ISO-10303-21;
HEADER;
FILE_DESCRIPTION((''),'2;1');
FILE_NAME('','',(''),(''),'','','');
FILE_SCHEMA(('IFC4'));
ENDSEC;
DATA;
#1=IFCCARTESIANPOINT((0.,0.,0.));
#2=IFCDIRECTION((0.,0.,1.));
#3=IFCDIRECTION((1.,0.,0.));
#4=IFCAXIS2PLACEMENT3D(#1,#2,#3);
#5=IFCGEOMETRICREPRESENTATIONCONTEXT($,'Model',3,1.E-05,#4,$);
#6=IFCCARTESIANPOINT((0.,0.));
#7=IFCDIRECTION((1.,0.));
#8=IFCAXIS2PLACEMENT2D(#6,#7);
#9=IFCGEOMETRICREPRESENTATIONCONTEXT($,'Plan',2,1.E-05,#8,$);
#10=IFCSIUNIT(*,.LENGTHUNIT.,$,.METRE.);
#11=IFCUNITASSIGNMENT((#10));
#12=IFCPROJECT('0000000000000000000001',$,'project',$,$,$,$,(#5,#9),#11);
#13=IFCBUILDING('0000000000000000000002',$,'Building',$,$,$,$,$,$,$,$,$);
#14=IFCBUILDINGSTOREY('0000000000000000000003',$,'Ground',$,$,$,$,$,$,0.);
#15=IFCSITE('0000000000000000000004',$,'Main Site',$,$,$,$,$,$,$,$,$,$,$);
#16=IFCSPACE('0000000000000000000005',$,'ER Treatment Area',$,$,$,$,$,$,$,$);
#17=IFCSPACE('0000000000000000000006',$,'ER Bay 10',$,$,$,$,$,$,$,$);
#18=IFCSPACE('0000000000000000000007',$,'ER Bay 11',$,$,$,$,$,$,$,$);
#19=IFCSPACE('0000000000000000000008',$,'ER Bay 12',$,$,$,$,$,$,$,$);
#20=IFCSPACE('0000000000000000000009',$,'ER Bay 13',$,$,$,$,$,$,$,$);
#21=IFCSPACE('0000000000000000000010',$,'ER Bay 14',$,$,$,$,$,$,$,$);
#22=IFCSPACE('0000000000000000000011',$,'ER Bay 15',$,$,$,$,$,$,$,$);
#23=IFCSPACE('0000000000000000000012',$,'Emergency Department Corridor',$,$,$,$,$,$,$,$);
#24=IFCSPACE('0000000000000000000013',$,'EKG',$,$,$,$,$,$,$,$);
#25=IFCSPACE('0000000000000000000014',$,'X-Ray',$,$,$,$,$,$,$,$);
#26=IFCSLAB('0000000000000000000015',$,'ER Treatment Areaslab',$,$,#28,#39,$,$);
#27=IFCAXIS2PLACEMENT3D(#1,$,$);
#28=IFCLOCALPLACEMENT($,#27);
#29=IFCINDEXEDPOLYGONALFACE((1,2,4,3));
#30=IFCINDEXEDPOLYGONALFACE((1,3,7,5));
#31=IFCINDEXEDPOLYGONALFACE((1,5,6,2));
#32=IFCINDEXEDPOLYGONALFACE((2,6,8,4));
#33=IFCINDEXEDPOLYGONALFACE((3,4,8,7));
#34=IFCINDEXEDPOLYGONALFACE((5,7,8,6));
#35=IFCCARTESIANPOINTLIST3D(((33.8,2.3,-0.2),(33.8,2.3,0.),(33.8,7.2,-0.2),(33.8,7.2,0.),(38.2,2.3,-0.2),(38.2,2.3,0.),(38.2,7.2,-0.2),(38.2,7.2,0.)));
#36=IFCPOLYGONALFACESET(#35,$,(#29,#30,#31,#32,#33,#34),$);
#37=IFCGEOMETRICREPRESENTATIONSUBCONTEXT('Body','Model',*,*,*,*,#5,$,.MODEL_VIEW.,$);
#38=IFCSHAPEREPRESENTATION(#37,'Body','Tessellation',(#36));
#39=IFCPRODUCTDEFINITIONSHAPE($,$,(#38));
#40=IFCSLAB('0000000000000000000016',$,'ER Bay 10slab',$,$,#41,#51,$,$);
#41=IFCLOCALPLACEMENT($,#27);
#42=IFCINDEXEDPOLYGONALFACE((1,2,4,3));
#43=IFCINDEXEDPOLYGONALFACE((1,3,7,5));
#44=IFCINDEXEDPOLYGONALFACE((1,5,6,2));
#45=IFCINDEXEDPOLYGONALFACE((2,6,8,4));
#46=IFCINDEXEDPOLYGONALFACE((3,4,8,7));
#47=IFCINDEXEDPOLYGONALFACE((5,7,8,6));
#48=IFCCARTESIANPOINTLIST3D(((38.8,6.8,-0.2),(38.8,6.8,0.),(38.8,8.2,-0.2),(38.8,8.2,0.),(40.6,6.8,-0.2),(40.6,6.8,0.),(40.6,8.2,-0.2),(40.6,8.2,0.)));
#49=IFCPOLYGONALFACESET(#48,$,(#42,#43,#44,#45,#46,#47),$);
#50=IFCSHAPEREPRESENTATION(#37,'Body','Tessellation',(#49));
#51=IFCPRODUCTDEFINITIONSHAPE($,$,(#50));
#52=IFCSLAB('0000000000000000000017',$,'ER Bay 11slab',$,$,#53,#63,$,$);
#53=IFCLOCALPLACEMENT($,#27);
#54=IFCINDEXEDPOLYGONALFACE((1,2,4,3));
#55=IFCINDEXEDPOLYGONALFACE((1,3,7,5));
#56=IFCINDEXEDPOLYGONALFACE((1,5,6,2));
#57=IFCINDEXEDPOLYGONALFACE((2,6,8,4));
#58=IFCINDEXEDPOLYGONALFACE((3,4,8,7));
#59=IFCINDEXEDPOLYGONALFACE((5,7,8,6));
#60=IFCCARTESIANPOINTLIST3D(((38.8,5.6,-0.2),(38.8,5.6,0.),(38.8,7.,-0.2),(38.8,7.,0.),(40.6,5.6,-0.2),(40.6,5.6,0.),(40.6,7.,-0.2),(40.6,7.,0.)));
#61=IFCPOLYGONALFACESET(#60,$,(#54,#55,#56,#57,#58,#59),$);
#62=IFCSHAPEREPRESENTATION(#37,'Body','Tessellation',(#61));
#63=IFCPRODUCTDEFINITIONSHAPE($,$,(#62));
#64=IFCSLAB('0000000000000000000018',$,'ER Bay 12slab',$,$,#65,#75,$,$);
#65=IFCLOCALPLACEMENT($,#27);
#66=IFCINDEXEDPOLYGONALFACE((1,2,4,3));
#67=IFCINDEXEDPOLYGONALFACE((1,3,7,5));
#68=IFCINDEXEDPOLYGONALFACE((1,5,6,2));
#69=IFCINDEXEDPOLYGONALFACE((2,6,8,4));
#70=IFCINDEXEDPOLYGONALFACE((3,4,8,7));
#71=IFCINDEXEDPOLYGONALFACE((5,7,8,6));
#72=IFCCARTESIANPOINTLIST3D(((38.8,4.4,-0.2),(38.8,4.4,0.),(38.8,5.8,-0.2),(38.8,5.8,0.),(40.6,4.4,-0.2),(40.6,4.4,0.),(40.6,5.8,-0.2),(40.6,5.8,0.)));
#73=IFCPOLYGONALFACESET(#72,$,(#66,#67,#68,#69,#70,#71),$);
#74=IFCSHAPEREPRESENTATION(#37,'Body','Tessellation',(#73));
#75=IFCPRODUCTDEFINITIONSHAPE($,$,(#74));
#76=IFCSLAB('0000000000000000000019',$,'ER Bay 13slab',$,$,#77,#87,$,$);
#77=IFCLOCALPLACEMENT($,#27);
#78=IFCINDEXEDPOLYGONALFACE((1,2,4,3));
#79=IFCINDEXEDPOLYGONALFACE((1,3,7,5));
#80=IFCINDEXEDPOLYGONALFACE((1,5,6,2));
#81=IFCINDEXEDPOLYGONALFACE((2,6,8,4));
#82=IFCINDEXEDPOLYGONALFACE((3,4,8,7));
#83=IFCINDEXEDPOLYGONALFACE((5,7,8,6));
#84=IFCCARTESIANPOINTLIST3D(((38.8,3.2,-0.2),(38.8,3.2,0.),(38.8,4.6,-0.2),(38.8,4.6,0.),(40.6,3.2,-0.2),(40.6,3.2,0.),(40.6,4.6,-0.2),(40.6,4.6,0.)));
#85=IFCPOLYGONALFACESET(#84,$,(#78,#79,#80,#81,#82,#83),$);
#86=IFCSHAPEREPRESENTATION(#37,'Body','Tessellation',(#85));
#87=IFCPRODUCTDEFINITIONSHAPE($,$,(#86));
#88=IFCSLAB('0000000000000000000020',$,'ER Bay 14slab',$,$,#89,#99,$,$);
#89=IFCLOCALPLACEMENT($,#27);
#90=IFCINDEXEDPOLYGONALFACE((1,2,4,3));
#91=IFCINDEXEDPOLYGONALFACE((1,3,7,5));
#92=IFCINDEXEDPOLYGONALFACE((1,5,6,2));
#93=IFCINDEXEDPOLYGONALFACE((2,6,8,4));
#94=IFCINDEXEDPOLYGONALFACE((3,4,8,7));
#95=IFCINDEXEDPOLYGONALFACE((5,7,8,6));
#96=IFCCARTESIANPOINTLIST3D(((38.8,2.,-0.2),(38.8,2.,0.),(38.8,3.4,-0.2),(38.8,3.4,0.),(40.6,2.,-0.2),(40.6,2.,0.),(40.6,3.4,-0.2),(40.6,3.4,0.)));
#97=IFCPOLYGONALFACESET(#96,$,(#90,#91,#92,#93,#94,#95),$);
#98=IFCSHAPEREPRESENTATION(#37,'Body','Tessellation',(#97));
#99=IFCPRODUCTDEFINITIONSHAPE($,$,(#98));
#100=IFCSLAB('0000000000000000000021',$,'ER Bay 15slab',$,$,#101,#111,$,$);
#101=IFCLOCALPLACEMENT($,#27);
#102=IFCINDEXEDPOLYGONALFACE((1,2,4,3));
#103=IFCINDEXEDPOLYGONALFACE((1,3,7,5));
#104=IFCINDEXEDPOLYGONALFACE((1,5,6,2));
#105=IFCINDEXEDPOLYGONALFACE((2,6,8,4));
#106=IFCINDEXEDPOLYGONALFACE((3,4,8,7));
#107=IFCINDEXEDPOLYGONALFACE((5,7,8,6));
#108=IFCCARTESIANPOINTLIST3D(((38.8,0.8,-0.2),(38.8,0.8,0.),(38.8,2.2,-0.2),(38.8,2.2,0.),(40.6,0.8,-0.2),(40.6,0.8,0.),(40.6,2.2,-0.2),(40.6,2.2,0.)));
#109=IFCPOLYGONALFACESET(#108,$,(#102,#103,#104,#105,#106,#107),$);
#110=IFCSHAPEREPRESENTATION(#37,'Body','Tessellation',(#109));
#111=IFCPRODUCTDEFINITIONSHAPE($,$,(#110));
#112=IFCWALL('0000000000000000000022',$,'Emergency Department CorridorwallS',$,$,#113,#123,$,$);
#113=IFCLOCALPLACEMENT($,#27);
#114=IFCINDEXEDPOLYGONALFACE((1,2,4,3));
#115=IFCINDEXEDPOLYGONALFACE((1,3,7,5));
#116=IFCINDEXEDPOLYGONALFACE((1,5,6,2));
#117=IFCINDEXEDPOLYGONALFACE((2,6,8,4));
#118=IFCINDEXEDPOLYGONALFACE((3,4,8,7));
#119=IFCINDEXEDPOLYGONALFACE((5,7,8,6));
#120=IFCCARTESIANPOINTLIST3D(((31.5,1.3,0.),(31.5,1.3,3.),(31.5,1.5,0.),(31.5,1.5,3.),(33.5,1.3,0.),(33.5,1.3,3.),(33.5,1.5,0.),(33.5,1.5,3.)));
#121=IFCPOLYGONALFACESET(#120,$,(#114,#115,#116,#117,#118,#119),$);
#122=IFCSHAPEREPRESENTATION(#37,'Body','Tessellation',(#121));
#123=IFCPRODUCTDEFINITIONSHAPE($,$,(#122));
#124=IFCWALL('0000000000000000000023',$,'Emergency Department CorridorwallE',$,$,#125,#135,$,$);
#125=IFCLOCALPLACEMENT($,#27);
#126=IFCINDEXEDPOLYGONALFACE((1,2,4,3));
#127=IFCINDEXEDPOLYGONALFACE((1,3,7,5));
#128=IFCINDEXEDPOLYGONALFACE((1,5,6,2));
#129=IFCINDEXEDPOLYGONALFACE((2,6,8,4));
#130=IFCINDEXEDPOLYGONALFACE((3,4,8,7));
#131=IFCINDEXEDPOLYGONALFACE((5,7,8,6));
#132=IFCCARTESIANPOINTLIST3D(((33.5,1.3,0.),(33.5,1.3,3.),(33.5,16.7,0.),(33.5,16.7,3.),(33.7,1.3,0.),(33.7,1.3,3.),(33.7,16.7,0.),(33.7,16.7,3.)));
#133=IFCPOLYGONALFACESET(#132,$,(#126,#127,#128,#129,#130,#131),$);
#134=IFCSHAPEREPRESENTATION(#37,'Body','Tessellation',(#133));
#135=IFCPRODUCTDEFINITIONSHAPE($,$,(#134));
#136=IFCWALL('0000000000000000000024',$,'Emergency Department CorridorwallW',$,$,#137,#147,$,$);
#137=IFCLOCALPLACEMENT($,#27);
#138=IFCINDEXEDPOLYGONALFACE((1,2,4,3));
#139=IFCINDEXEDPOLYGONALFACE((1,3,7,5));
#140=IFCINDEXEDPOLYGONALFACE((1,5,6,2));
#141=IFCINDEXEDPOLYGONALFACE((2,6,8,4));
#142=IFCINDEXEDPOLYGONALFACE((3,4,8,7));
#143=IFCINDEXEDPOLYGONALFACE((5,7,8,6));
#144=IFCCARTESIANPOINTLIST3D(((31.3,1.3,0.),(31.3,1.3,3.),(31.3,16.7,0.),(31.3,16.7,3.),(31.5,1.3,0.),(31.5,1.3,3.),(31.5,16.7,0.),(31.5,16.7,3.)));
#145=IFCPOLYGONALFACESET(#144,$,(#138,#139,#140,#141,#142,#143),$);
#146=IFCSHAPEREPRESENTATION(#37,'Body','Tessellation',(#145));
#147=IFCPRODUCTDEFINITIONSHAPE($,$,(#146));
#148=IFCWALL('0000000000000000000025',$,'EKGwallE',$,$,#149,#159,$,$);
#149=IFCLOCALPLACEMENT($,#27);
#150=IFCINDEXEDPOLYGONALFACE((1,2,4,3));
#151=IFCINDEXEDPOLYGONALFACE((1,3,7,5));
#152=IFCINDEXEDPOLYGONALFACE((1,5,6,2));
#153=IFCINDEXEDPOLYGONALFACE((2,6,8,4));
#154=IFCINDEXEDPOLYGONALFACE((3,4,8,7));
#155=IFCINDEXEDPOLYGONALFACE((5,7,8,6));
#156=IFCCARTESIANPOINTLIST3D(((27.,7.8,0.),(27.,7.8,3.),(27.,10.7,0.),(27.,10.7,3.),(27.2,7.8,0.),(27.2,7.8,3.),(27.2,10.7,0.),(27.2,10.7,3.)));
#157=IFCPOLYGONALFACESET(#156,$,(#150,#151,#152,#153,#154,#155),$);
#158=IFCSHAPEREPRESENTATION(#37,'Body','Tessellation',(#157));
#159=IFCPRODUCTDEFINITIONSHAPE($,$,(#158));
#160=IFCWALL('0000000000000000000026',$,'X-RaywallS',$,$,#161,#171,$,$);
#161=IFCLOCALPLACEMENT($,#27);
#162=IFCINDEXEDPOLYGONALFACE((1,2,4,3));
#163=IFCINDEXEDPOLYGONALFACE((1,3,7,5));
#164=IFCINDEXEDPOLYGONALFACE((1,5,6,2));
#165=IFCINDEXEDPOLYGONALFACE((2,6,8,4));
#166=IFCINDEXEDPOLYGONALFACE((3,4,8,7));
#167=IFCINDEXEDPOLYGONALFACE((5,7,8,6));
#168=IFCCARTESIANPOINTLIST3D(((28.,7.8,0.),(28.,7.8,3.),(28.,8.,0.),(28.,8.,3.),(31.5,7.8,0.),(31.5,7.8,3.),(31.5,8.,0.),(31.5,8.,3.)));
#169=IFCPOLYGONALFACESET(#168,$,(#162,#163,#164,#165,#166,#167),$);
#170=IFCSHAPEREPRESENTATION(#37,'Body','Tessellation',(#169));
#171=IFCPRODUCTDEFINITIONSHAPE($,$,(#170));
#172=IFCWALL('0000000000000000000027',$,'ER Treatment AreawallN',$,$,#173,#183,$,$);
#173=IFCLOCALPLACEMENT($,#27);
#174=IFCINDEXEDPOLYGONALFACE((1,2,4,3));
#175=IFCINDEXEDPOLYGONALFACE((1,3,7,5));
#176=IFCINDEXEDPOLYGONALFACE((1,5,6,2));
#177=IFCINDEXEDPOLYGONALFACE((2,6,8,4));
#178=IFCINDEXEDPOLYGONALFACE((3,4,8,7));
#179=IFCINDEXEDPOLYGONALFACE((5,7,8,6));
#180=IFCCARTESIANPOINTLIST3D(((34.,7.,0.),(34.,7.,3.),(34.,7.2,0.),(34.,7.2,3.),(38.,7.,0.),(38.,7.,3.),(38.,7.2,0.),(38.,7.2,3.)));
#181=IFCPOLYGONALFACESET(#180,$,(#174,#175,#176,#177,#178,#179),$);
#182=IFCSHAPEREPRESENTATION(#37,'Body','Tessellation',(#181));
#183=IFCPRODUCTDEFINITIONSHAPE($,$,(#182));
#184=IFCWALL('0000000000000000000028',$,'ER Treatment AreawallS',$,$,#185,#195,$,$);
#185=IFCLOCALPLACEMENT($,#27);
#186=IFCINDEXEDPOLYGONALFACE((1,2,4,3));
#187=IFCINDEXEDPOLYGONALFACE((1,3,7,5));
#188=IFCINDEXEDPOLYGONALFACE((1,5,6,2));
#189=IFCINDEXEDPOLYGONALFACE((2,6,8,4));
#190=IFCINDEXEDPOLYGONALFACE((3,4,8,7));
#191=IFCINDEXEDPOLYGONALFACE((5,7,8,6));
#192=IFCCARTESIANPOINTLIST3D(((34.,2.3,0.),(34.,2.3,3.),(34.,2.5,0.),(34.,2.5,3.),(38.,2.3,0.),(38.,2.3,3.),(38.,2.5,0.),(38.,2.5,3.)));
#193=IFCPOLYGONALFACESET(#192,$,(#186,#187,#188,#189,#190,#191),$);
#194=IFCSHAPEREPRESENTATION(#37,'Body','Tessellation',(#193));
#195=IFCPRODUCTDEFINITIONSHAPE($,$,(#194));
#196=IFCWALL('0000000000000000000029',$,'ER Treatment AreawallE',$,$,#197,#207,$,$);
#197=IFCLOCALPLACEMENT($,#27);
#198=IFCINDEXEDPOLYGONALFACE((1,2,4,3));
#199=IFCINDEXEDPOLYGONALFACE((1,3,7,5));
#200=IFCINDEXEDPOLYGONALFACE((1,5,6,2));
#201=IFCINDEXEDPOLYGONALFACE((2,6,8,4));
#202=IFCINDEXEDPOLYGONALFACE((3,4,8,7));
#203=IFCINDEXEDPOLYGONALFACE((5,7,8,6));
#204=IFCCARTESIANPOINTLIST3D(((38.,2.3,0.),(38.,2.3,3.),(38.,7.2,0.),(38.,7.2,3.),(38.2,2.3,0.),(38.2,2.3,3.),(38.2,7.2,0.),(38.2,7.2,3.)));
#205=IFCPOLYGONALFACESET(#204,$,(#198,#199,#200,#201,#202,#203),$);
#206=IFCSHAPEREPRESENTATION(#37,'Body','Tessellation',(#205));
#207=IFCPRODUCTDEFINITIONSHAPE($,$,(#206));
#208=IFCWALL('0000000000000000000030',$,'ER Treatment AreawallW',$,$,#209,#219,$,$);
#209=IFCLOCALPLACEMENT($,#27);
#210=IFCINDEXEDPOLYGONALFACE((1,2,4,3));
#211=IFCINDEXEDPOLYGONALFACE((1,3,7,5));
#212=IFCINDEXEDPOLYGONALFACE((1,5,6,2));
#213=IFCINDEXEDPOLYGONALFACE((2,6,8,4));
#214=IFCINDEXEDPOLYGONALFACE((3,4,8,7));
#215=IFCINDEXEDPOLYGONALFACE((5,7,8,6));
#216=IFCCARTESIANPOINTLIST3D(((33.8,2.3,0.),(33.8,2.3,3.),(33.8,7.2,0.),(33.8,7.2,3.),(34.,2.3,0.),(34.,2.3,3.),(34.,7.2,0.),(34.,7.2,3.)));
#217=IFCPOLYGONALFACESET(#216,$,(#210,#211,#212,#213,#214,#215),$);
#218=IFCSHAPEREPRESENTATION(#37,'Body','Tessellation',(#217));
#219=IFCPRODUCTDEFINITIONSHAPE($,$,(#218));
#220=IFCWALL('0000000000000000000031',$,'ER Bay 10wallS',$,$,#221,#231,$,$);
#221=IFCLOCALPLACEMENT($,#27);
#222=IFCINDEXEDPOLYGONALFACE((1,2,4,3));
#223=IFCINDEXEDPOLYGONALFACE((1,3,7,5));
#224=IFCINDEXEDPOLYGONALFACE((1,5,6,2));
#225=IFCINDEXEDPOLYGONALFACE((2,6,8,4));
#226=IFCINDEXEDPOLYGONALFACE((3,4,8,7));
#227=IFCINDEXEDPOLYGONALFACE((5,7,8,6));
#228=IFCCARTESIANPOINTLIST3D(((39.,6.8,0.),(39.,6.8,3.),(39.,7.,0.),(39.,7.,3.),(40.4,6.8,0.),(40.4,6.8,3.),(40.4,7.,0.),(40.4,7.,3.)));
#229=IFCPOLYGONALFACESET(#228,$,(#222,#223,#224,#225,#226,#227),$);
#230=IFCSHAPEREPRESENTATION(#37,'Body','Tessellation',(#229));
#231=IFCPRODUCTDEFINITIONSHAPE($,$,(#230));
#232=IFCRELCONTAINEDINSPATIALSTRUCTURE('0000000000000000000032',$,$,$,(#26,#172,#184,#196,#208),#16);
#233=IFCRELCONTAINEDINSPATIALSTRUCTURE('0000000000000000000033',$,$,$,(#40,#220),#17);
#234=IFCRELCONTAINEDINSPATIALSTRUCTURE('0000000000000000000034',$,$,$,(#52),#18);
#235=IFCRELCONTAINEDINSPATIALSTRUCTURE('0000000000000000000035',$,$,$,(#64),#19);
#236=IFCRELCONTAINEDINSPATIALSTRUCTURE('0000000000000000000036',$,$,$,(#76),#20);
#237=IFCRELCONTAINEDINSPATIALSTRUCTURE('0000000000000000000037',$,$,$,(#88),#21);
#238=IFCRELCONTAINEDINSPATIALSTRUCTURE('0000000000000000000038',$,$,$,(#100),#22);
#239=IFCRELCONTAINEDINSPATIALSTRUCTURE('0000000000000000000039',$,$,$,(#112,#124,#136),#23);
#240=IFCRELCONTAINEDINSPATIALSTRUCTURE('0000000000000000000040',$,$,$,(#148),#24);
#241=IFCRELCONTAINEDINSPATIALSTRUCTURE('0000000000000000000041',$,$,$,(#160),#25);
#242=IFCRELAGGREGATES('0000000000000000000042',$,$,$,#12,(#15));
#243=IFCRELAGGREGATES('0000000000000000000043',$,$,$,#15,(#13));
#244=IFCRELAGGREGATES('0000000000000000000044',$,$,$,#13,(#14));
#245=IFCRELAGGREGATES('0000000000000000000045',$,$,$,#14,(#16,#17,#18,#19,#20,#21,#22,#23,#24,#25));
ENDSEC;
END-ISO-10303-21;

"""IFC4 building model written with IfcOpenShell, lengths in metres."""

from ifc_helpers import new_model, si_unit, frame, origin_with_axes, origin_2d_with_axis, place, context, subcontext, project, spatial, indexed_curve, rectangle, outline, extrude, element, save


model = new_model("IFC4")

# Units and contexts
model_context = context("Model", 3, precision=1e-05, world=origin_with_axes())
plan_context = context("Plan", 2, precision=1e-05, world=origin_2d_with_axis())
body_context = subcontext(model_context, "Body", "Model", "MODEL_VIEW")
ifc_project = project(units=[si_unit("LENGTHUNIT", "METRE")], contexts=[model_context, plan_context])

# Site, building, storey, space
site = spatial("IfcSite", under=ifc_project, Name="Main Site")
building = spatial("IfcBuilding", under=site, Name="Building")
storey = spatial("IfcBuildingStorey", under=building, Name="Ground", Elevation=0.0)
space_1 = spatial("IfcSpace", under=storey, Name="ER Treatment Area")

# Slab
slab_1_placement = place(None, frame((36.0, 4.75, -0.2), z_axis=(0.0, 0.0, 1.0), x_axis=(1.0, 0.0, 0.0)))
element("IfcSlab", 1, at=slab_1_placement, inside=space_1, Name="ER Treatment Areaslab", context=body_context, shape_type="SweptSolid", body=[
    extrude(rectangle(XDim=4.4, YDim=4.9), origin_with_axes(), (0.0, 0.0, 1.0), 0.2),
])

# Shared definitions
space_2 = spatial("IfcSpace", under=storey, Name="ER Bay 10")

# Slab
slab_2_placement = place(None, frame((39.7, 7.5, -0.2), z_axis=(0.0, 0.0, 1.0), x_axis=(1.0, 0.0, 0.0)))
element("IfcSlab", 2, at=slab_2_placement, inside=space_2, Name="ER Bay 10slab", context=body_context, shape_type="SweptSolid", body=[
    extrude(rectangle(XDim=1.8, YDim=1.4), origin_with_axes(), (0.0, 0.0, 1.0), 0.2),
])

# Shared definitions
space_3 = spatial("IfcSpace", under=storey, Name="ER Bay 11")

# Slab
slab_3_placement = place(None, frame((39.7, 6.3, -0.2), z_axis=(0.0, 0.0, 1.0), x_axis=(1.0, 0.0, 0.0)))
element("IfcSlab", 3, at=slab_3_placement, inside=space_3, Name="ER Bay 11slab", context=body_context, shape_type="SweptSolid", body=[
    extrude(rectangle(XDim=1.8, YDim=1.4), origin_with_axes(), (0.0, 0.0, 1.0), 0.2),
])

# Shared definitions
space_4 = spatial("IfcSpace", under=storey, Name="ER Bay 12")

# Slab
slab_4_placement = place(None, frame((39.7, 5.1, -0.2), z_axis=(0.0, 0.0, 1.0), x_axis=(1.0, 0.0, 0.0)))
element("IfcSlab", 4, at=slab_4_placement, inside=space_4, Name="ER Bay 12slab", context=body_context, shape_type="SweptSolid", body=[
    extrude(rectangle(XDim=1.8, YDim=1.4), origin_with_axes(), (0.0, 0.0, 1.0), 0.2),
])

# Shared definitions
space_5 = spatial("IfcSpace", under=storey, Name="ER Bay 13")

# Slab
slab_5_placement = place(None, frame((39.7, 3.9, -0.2), z_axis=(0.0, 0.0, 1.0), x_axis=(1.0, 0.0, 0.0)))
element("IfcSlab", 5, at=slab_5_placement, inside=space_5, Name="ER Bay 13slab", context=body_context, shape_type="SweptSolid", body=[
    extrude(rectangle(XDim=1.8, YDim=1.4), origin_with_axes(), (0.0, 0.0, 1.0), 0.2),
])

# Shared definitions
space_6 = spatial("IfcSpace", under=storey, Name="ER Bay 14")

# Slab
slab_6_placement = place(None, frame((39.7, 2.7, -0.2), z_axis=(0.0, 0.0, 1.0), x_axis=(1.0, 0.0, 0.0)))
element("IfcSlab", 6, at=slab_6_placement, inside=space_6, Name="ER Bay 14slab", context=body_context, shape_type="SweptSolid", body=[
    extrude(rectangle(XDim=1.8, YDim=1.4), origin_with_axes(), (0.0, 0.0, 1.0), 0.2),
])

# Shared definitions
space_7 = spatial("IfcSpace", under=storey, Name="ER Bay 15")

# Slab
slab_7_placement = place(None, frame((39.7, 1.5, -0.2), z_axis=(0.0, 0.0, 1.0), x_axis=(1.0, 0.0, 0.0)))
element("IfcSlab", 7, at=slab_7_placement, inside=space_7, Name="ER Bay 15slab", context=body_context, shape_type="SweptSolid", body=[
    extrude(rectangle(XDim=1.8, YDim=1.4), origin_with_axes(), (0.0, 0.0, 1.0), 0.2),
])

# Shared definitions
space_8 = spatial("IfcSpace", under=storey, Name="Emergency Department Corridor")

# Walls
wall_1_placement = place(None, frame((31.5, 1.3, 0.0), z_axis=(0.0, 0.0, 1.0), x_axis=(1.0, 0.0, 0.0)))
element("IfcWall", 8, at=wall_1_placement, inside=space_8, Name="Emergency Department CorridorwallS", context=body_context, shape_type="SweptSolid", body=[
    extrude(outline(indexed_curve([(0.0, 0.0), (0.0, 0.2), (2.0, 0.2), (2.0, 0.0), (0.0, 0.0)], self_intersect=False)), origin_with_axes(), (0.0, 0.0, 1.0), 3.0),
])
for number, where, z_axis, x_axis, name in (
    (9, (33.7, 1.3, 0.0), (0.0, 0.0, 1.0), (0.0, 1.0, 0.0), "Emergency Department CorridorwallE"),
    (10, (31.5, 1.3, 0.0), (0.0, 0.0, 1.0), (0.0, 1.0, 0.0), "Emergency Department CorridorwallW"),
):
    element("IfcWall", number, at=place(None, frame(where, z_axis=z_axis, x_axis=x_axis)), inside=space_8, Name=name, context=body_context, shape_type="SweptSolid", body=[
        extrude(outline(indexed_curve([(0.0, 0.0), (0.0, 0.2), (15.4, 0.2), (15.4, 0.0), (0.0, 0.0)], self_intersect=False)), origin_with_axes(), (0.0, 0.0, 1.0), 3.0),
    ])

# Shared definitions
space_9 = spatial("IfcSpace", under=storey, Name="EKG")

# Wall
wall_2_placement = place(None, frame((27.2, 7.8, 0.0), z_axis=(0.0, 0.0, 1.0), x_axis=(0.0, 1.0, 0.0)))
element("IfcWall", 11, at=wall_2_placement, inside=space_9, Name="EKGwallE", context=body_context, shape_type="SweptSolid", body=[
    extrude(outline(indexed_curve([(0.0, 0.0), (0.0, 0.2), (2.9, 0.2), (2.9, 0.0), (0.0, 0.0)], self_intersect=False)), origin_with_axes(), (0.0, 0.0, 1.0), 3.0),
])

# Shared definitions
space_10 = spatial("IfcSpace", under=storey, Name="X-Ray")

# Walls
wall_3_placement = place(None, frame((28.0, 7.8, 0.0), z_axis=(0.0, 0.0, 1.0), x_axis=(1.0, 0.0, 0.0)))
element("IfcWall", 12, at=wall_3_placement, inside=space_10, Name="X-RaywallS", context=body_context, shape_type="SweptSolid", body=[
    extrude(outline(indexed_curve([(0.0, 0.0), (0.0, 0.2), (3.5, 0.2), (3.5, 0.0), (0.0, 0.0)], self_intersect=False)), origin_with_axes(), (0.0, 0.0, 1.0), 3.0),
])
for number, where, z_axis, x_axis, name in (
    (13, (34.0, 7.0, 0.0), (0.0, 0.0, 1.0), (1.0, 0.0, 0.0), "ER Treatment AreawallN"),
    (14, (34.0, 2.3, 0.0), (0.0, 0.0, 1.0), (1.0, 0.0, 0.0), "ER Treatment AreawallS"),
):
    element("IfcWall", number, at=place(None, frame(where, z_axis=z_axis, x_axis=x_axis)), inside=space_1, Name=name, context=body_context, shape_type="SweptSolid", body=[
        extrude(outline(indexed_curve([(0.0, 0.0), (0.0, 0.2), (4.0, 0.2), (4.0, 0.0), (0.0, 0.0)], self_intersect=False)), origin_with_axes(), (0.0, 0.0, 1.0), 3.0),
    ])
for number, where, z_axis, x_axis, name in (
    (15, (38.2, 2.3, 0.0), (0.0, 0.0, 1.0), (0.0, 1.0, 0.0), "ER Treatment AreawallE"),
    (16, (34.0, 2.3, 0.0), (0.0, 0.0, 1.0), (0.0, 1.0, 0.0), "ER Treatment AreawallW"),
):
    element("IfcWall", number, at=place(None, frame(where, z_axis=z_axis, x_axis=x_axis)), inside=space_1, Name=name, context=body_context, shape_type="SweptSolid", body=[
        extrude(outline(indexed_curve([(0.0, 0.0), (0.0, 0.2), (4.9, 0.2), (4.9, 0.0), (0.0, 0.0)], self_intersect=False)), origin_with_axes(), (0.0, 0.0, 1.0), 3.0),
    ])
for number, where, z_axis, x_axis, name in (
    (17, (39.0, 6.8, 0.0), (0.0, 0.0, 1.0), (1.0, 0.0, 0.0), "ER Bay 10wallS"),
):
    element("IfcWall", number, at=place(None, frame(where, z_axis=z_axis, x_axis=x_axis)), inside=space_2, Name=name, context=body_context, shape_type="SweptSolid", body=[
        extrude(outline(indexed_curve([(0.0, 0.0), (0.0, 0.2), (1.4, 0.2), (1.4, 0.0), (0.0, 0.0)], self_intersect=False)), origin_with_axes(), (0.0, 0.0, 1.0), 3.0),
    ])

save(model, "model.ifc")
